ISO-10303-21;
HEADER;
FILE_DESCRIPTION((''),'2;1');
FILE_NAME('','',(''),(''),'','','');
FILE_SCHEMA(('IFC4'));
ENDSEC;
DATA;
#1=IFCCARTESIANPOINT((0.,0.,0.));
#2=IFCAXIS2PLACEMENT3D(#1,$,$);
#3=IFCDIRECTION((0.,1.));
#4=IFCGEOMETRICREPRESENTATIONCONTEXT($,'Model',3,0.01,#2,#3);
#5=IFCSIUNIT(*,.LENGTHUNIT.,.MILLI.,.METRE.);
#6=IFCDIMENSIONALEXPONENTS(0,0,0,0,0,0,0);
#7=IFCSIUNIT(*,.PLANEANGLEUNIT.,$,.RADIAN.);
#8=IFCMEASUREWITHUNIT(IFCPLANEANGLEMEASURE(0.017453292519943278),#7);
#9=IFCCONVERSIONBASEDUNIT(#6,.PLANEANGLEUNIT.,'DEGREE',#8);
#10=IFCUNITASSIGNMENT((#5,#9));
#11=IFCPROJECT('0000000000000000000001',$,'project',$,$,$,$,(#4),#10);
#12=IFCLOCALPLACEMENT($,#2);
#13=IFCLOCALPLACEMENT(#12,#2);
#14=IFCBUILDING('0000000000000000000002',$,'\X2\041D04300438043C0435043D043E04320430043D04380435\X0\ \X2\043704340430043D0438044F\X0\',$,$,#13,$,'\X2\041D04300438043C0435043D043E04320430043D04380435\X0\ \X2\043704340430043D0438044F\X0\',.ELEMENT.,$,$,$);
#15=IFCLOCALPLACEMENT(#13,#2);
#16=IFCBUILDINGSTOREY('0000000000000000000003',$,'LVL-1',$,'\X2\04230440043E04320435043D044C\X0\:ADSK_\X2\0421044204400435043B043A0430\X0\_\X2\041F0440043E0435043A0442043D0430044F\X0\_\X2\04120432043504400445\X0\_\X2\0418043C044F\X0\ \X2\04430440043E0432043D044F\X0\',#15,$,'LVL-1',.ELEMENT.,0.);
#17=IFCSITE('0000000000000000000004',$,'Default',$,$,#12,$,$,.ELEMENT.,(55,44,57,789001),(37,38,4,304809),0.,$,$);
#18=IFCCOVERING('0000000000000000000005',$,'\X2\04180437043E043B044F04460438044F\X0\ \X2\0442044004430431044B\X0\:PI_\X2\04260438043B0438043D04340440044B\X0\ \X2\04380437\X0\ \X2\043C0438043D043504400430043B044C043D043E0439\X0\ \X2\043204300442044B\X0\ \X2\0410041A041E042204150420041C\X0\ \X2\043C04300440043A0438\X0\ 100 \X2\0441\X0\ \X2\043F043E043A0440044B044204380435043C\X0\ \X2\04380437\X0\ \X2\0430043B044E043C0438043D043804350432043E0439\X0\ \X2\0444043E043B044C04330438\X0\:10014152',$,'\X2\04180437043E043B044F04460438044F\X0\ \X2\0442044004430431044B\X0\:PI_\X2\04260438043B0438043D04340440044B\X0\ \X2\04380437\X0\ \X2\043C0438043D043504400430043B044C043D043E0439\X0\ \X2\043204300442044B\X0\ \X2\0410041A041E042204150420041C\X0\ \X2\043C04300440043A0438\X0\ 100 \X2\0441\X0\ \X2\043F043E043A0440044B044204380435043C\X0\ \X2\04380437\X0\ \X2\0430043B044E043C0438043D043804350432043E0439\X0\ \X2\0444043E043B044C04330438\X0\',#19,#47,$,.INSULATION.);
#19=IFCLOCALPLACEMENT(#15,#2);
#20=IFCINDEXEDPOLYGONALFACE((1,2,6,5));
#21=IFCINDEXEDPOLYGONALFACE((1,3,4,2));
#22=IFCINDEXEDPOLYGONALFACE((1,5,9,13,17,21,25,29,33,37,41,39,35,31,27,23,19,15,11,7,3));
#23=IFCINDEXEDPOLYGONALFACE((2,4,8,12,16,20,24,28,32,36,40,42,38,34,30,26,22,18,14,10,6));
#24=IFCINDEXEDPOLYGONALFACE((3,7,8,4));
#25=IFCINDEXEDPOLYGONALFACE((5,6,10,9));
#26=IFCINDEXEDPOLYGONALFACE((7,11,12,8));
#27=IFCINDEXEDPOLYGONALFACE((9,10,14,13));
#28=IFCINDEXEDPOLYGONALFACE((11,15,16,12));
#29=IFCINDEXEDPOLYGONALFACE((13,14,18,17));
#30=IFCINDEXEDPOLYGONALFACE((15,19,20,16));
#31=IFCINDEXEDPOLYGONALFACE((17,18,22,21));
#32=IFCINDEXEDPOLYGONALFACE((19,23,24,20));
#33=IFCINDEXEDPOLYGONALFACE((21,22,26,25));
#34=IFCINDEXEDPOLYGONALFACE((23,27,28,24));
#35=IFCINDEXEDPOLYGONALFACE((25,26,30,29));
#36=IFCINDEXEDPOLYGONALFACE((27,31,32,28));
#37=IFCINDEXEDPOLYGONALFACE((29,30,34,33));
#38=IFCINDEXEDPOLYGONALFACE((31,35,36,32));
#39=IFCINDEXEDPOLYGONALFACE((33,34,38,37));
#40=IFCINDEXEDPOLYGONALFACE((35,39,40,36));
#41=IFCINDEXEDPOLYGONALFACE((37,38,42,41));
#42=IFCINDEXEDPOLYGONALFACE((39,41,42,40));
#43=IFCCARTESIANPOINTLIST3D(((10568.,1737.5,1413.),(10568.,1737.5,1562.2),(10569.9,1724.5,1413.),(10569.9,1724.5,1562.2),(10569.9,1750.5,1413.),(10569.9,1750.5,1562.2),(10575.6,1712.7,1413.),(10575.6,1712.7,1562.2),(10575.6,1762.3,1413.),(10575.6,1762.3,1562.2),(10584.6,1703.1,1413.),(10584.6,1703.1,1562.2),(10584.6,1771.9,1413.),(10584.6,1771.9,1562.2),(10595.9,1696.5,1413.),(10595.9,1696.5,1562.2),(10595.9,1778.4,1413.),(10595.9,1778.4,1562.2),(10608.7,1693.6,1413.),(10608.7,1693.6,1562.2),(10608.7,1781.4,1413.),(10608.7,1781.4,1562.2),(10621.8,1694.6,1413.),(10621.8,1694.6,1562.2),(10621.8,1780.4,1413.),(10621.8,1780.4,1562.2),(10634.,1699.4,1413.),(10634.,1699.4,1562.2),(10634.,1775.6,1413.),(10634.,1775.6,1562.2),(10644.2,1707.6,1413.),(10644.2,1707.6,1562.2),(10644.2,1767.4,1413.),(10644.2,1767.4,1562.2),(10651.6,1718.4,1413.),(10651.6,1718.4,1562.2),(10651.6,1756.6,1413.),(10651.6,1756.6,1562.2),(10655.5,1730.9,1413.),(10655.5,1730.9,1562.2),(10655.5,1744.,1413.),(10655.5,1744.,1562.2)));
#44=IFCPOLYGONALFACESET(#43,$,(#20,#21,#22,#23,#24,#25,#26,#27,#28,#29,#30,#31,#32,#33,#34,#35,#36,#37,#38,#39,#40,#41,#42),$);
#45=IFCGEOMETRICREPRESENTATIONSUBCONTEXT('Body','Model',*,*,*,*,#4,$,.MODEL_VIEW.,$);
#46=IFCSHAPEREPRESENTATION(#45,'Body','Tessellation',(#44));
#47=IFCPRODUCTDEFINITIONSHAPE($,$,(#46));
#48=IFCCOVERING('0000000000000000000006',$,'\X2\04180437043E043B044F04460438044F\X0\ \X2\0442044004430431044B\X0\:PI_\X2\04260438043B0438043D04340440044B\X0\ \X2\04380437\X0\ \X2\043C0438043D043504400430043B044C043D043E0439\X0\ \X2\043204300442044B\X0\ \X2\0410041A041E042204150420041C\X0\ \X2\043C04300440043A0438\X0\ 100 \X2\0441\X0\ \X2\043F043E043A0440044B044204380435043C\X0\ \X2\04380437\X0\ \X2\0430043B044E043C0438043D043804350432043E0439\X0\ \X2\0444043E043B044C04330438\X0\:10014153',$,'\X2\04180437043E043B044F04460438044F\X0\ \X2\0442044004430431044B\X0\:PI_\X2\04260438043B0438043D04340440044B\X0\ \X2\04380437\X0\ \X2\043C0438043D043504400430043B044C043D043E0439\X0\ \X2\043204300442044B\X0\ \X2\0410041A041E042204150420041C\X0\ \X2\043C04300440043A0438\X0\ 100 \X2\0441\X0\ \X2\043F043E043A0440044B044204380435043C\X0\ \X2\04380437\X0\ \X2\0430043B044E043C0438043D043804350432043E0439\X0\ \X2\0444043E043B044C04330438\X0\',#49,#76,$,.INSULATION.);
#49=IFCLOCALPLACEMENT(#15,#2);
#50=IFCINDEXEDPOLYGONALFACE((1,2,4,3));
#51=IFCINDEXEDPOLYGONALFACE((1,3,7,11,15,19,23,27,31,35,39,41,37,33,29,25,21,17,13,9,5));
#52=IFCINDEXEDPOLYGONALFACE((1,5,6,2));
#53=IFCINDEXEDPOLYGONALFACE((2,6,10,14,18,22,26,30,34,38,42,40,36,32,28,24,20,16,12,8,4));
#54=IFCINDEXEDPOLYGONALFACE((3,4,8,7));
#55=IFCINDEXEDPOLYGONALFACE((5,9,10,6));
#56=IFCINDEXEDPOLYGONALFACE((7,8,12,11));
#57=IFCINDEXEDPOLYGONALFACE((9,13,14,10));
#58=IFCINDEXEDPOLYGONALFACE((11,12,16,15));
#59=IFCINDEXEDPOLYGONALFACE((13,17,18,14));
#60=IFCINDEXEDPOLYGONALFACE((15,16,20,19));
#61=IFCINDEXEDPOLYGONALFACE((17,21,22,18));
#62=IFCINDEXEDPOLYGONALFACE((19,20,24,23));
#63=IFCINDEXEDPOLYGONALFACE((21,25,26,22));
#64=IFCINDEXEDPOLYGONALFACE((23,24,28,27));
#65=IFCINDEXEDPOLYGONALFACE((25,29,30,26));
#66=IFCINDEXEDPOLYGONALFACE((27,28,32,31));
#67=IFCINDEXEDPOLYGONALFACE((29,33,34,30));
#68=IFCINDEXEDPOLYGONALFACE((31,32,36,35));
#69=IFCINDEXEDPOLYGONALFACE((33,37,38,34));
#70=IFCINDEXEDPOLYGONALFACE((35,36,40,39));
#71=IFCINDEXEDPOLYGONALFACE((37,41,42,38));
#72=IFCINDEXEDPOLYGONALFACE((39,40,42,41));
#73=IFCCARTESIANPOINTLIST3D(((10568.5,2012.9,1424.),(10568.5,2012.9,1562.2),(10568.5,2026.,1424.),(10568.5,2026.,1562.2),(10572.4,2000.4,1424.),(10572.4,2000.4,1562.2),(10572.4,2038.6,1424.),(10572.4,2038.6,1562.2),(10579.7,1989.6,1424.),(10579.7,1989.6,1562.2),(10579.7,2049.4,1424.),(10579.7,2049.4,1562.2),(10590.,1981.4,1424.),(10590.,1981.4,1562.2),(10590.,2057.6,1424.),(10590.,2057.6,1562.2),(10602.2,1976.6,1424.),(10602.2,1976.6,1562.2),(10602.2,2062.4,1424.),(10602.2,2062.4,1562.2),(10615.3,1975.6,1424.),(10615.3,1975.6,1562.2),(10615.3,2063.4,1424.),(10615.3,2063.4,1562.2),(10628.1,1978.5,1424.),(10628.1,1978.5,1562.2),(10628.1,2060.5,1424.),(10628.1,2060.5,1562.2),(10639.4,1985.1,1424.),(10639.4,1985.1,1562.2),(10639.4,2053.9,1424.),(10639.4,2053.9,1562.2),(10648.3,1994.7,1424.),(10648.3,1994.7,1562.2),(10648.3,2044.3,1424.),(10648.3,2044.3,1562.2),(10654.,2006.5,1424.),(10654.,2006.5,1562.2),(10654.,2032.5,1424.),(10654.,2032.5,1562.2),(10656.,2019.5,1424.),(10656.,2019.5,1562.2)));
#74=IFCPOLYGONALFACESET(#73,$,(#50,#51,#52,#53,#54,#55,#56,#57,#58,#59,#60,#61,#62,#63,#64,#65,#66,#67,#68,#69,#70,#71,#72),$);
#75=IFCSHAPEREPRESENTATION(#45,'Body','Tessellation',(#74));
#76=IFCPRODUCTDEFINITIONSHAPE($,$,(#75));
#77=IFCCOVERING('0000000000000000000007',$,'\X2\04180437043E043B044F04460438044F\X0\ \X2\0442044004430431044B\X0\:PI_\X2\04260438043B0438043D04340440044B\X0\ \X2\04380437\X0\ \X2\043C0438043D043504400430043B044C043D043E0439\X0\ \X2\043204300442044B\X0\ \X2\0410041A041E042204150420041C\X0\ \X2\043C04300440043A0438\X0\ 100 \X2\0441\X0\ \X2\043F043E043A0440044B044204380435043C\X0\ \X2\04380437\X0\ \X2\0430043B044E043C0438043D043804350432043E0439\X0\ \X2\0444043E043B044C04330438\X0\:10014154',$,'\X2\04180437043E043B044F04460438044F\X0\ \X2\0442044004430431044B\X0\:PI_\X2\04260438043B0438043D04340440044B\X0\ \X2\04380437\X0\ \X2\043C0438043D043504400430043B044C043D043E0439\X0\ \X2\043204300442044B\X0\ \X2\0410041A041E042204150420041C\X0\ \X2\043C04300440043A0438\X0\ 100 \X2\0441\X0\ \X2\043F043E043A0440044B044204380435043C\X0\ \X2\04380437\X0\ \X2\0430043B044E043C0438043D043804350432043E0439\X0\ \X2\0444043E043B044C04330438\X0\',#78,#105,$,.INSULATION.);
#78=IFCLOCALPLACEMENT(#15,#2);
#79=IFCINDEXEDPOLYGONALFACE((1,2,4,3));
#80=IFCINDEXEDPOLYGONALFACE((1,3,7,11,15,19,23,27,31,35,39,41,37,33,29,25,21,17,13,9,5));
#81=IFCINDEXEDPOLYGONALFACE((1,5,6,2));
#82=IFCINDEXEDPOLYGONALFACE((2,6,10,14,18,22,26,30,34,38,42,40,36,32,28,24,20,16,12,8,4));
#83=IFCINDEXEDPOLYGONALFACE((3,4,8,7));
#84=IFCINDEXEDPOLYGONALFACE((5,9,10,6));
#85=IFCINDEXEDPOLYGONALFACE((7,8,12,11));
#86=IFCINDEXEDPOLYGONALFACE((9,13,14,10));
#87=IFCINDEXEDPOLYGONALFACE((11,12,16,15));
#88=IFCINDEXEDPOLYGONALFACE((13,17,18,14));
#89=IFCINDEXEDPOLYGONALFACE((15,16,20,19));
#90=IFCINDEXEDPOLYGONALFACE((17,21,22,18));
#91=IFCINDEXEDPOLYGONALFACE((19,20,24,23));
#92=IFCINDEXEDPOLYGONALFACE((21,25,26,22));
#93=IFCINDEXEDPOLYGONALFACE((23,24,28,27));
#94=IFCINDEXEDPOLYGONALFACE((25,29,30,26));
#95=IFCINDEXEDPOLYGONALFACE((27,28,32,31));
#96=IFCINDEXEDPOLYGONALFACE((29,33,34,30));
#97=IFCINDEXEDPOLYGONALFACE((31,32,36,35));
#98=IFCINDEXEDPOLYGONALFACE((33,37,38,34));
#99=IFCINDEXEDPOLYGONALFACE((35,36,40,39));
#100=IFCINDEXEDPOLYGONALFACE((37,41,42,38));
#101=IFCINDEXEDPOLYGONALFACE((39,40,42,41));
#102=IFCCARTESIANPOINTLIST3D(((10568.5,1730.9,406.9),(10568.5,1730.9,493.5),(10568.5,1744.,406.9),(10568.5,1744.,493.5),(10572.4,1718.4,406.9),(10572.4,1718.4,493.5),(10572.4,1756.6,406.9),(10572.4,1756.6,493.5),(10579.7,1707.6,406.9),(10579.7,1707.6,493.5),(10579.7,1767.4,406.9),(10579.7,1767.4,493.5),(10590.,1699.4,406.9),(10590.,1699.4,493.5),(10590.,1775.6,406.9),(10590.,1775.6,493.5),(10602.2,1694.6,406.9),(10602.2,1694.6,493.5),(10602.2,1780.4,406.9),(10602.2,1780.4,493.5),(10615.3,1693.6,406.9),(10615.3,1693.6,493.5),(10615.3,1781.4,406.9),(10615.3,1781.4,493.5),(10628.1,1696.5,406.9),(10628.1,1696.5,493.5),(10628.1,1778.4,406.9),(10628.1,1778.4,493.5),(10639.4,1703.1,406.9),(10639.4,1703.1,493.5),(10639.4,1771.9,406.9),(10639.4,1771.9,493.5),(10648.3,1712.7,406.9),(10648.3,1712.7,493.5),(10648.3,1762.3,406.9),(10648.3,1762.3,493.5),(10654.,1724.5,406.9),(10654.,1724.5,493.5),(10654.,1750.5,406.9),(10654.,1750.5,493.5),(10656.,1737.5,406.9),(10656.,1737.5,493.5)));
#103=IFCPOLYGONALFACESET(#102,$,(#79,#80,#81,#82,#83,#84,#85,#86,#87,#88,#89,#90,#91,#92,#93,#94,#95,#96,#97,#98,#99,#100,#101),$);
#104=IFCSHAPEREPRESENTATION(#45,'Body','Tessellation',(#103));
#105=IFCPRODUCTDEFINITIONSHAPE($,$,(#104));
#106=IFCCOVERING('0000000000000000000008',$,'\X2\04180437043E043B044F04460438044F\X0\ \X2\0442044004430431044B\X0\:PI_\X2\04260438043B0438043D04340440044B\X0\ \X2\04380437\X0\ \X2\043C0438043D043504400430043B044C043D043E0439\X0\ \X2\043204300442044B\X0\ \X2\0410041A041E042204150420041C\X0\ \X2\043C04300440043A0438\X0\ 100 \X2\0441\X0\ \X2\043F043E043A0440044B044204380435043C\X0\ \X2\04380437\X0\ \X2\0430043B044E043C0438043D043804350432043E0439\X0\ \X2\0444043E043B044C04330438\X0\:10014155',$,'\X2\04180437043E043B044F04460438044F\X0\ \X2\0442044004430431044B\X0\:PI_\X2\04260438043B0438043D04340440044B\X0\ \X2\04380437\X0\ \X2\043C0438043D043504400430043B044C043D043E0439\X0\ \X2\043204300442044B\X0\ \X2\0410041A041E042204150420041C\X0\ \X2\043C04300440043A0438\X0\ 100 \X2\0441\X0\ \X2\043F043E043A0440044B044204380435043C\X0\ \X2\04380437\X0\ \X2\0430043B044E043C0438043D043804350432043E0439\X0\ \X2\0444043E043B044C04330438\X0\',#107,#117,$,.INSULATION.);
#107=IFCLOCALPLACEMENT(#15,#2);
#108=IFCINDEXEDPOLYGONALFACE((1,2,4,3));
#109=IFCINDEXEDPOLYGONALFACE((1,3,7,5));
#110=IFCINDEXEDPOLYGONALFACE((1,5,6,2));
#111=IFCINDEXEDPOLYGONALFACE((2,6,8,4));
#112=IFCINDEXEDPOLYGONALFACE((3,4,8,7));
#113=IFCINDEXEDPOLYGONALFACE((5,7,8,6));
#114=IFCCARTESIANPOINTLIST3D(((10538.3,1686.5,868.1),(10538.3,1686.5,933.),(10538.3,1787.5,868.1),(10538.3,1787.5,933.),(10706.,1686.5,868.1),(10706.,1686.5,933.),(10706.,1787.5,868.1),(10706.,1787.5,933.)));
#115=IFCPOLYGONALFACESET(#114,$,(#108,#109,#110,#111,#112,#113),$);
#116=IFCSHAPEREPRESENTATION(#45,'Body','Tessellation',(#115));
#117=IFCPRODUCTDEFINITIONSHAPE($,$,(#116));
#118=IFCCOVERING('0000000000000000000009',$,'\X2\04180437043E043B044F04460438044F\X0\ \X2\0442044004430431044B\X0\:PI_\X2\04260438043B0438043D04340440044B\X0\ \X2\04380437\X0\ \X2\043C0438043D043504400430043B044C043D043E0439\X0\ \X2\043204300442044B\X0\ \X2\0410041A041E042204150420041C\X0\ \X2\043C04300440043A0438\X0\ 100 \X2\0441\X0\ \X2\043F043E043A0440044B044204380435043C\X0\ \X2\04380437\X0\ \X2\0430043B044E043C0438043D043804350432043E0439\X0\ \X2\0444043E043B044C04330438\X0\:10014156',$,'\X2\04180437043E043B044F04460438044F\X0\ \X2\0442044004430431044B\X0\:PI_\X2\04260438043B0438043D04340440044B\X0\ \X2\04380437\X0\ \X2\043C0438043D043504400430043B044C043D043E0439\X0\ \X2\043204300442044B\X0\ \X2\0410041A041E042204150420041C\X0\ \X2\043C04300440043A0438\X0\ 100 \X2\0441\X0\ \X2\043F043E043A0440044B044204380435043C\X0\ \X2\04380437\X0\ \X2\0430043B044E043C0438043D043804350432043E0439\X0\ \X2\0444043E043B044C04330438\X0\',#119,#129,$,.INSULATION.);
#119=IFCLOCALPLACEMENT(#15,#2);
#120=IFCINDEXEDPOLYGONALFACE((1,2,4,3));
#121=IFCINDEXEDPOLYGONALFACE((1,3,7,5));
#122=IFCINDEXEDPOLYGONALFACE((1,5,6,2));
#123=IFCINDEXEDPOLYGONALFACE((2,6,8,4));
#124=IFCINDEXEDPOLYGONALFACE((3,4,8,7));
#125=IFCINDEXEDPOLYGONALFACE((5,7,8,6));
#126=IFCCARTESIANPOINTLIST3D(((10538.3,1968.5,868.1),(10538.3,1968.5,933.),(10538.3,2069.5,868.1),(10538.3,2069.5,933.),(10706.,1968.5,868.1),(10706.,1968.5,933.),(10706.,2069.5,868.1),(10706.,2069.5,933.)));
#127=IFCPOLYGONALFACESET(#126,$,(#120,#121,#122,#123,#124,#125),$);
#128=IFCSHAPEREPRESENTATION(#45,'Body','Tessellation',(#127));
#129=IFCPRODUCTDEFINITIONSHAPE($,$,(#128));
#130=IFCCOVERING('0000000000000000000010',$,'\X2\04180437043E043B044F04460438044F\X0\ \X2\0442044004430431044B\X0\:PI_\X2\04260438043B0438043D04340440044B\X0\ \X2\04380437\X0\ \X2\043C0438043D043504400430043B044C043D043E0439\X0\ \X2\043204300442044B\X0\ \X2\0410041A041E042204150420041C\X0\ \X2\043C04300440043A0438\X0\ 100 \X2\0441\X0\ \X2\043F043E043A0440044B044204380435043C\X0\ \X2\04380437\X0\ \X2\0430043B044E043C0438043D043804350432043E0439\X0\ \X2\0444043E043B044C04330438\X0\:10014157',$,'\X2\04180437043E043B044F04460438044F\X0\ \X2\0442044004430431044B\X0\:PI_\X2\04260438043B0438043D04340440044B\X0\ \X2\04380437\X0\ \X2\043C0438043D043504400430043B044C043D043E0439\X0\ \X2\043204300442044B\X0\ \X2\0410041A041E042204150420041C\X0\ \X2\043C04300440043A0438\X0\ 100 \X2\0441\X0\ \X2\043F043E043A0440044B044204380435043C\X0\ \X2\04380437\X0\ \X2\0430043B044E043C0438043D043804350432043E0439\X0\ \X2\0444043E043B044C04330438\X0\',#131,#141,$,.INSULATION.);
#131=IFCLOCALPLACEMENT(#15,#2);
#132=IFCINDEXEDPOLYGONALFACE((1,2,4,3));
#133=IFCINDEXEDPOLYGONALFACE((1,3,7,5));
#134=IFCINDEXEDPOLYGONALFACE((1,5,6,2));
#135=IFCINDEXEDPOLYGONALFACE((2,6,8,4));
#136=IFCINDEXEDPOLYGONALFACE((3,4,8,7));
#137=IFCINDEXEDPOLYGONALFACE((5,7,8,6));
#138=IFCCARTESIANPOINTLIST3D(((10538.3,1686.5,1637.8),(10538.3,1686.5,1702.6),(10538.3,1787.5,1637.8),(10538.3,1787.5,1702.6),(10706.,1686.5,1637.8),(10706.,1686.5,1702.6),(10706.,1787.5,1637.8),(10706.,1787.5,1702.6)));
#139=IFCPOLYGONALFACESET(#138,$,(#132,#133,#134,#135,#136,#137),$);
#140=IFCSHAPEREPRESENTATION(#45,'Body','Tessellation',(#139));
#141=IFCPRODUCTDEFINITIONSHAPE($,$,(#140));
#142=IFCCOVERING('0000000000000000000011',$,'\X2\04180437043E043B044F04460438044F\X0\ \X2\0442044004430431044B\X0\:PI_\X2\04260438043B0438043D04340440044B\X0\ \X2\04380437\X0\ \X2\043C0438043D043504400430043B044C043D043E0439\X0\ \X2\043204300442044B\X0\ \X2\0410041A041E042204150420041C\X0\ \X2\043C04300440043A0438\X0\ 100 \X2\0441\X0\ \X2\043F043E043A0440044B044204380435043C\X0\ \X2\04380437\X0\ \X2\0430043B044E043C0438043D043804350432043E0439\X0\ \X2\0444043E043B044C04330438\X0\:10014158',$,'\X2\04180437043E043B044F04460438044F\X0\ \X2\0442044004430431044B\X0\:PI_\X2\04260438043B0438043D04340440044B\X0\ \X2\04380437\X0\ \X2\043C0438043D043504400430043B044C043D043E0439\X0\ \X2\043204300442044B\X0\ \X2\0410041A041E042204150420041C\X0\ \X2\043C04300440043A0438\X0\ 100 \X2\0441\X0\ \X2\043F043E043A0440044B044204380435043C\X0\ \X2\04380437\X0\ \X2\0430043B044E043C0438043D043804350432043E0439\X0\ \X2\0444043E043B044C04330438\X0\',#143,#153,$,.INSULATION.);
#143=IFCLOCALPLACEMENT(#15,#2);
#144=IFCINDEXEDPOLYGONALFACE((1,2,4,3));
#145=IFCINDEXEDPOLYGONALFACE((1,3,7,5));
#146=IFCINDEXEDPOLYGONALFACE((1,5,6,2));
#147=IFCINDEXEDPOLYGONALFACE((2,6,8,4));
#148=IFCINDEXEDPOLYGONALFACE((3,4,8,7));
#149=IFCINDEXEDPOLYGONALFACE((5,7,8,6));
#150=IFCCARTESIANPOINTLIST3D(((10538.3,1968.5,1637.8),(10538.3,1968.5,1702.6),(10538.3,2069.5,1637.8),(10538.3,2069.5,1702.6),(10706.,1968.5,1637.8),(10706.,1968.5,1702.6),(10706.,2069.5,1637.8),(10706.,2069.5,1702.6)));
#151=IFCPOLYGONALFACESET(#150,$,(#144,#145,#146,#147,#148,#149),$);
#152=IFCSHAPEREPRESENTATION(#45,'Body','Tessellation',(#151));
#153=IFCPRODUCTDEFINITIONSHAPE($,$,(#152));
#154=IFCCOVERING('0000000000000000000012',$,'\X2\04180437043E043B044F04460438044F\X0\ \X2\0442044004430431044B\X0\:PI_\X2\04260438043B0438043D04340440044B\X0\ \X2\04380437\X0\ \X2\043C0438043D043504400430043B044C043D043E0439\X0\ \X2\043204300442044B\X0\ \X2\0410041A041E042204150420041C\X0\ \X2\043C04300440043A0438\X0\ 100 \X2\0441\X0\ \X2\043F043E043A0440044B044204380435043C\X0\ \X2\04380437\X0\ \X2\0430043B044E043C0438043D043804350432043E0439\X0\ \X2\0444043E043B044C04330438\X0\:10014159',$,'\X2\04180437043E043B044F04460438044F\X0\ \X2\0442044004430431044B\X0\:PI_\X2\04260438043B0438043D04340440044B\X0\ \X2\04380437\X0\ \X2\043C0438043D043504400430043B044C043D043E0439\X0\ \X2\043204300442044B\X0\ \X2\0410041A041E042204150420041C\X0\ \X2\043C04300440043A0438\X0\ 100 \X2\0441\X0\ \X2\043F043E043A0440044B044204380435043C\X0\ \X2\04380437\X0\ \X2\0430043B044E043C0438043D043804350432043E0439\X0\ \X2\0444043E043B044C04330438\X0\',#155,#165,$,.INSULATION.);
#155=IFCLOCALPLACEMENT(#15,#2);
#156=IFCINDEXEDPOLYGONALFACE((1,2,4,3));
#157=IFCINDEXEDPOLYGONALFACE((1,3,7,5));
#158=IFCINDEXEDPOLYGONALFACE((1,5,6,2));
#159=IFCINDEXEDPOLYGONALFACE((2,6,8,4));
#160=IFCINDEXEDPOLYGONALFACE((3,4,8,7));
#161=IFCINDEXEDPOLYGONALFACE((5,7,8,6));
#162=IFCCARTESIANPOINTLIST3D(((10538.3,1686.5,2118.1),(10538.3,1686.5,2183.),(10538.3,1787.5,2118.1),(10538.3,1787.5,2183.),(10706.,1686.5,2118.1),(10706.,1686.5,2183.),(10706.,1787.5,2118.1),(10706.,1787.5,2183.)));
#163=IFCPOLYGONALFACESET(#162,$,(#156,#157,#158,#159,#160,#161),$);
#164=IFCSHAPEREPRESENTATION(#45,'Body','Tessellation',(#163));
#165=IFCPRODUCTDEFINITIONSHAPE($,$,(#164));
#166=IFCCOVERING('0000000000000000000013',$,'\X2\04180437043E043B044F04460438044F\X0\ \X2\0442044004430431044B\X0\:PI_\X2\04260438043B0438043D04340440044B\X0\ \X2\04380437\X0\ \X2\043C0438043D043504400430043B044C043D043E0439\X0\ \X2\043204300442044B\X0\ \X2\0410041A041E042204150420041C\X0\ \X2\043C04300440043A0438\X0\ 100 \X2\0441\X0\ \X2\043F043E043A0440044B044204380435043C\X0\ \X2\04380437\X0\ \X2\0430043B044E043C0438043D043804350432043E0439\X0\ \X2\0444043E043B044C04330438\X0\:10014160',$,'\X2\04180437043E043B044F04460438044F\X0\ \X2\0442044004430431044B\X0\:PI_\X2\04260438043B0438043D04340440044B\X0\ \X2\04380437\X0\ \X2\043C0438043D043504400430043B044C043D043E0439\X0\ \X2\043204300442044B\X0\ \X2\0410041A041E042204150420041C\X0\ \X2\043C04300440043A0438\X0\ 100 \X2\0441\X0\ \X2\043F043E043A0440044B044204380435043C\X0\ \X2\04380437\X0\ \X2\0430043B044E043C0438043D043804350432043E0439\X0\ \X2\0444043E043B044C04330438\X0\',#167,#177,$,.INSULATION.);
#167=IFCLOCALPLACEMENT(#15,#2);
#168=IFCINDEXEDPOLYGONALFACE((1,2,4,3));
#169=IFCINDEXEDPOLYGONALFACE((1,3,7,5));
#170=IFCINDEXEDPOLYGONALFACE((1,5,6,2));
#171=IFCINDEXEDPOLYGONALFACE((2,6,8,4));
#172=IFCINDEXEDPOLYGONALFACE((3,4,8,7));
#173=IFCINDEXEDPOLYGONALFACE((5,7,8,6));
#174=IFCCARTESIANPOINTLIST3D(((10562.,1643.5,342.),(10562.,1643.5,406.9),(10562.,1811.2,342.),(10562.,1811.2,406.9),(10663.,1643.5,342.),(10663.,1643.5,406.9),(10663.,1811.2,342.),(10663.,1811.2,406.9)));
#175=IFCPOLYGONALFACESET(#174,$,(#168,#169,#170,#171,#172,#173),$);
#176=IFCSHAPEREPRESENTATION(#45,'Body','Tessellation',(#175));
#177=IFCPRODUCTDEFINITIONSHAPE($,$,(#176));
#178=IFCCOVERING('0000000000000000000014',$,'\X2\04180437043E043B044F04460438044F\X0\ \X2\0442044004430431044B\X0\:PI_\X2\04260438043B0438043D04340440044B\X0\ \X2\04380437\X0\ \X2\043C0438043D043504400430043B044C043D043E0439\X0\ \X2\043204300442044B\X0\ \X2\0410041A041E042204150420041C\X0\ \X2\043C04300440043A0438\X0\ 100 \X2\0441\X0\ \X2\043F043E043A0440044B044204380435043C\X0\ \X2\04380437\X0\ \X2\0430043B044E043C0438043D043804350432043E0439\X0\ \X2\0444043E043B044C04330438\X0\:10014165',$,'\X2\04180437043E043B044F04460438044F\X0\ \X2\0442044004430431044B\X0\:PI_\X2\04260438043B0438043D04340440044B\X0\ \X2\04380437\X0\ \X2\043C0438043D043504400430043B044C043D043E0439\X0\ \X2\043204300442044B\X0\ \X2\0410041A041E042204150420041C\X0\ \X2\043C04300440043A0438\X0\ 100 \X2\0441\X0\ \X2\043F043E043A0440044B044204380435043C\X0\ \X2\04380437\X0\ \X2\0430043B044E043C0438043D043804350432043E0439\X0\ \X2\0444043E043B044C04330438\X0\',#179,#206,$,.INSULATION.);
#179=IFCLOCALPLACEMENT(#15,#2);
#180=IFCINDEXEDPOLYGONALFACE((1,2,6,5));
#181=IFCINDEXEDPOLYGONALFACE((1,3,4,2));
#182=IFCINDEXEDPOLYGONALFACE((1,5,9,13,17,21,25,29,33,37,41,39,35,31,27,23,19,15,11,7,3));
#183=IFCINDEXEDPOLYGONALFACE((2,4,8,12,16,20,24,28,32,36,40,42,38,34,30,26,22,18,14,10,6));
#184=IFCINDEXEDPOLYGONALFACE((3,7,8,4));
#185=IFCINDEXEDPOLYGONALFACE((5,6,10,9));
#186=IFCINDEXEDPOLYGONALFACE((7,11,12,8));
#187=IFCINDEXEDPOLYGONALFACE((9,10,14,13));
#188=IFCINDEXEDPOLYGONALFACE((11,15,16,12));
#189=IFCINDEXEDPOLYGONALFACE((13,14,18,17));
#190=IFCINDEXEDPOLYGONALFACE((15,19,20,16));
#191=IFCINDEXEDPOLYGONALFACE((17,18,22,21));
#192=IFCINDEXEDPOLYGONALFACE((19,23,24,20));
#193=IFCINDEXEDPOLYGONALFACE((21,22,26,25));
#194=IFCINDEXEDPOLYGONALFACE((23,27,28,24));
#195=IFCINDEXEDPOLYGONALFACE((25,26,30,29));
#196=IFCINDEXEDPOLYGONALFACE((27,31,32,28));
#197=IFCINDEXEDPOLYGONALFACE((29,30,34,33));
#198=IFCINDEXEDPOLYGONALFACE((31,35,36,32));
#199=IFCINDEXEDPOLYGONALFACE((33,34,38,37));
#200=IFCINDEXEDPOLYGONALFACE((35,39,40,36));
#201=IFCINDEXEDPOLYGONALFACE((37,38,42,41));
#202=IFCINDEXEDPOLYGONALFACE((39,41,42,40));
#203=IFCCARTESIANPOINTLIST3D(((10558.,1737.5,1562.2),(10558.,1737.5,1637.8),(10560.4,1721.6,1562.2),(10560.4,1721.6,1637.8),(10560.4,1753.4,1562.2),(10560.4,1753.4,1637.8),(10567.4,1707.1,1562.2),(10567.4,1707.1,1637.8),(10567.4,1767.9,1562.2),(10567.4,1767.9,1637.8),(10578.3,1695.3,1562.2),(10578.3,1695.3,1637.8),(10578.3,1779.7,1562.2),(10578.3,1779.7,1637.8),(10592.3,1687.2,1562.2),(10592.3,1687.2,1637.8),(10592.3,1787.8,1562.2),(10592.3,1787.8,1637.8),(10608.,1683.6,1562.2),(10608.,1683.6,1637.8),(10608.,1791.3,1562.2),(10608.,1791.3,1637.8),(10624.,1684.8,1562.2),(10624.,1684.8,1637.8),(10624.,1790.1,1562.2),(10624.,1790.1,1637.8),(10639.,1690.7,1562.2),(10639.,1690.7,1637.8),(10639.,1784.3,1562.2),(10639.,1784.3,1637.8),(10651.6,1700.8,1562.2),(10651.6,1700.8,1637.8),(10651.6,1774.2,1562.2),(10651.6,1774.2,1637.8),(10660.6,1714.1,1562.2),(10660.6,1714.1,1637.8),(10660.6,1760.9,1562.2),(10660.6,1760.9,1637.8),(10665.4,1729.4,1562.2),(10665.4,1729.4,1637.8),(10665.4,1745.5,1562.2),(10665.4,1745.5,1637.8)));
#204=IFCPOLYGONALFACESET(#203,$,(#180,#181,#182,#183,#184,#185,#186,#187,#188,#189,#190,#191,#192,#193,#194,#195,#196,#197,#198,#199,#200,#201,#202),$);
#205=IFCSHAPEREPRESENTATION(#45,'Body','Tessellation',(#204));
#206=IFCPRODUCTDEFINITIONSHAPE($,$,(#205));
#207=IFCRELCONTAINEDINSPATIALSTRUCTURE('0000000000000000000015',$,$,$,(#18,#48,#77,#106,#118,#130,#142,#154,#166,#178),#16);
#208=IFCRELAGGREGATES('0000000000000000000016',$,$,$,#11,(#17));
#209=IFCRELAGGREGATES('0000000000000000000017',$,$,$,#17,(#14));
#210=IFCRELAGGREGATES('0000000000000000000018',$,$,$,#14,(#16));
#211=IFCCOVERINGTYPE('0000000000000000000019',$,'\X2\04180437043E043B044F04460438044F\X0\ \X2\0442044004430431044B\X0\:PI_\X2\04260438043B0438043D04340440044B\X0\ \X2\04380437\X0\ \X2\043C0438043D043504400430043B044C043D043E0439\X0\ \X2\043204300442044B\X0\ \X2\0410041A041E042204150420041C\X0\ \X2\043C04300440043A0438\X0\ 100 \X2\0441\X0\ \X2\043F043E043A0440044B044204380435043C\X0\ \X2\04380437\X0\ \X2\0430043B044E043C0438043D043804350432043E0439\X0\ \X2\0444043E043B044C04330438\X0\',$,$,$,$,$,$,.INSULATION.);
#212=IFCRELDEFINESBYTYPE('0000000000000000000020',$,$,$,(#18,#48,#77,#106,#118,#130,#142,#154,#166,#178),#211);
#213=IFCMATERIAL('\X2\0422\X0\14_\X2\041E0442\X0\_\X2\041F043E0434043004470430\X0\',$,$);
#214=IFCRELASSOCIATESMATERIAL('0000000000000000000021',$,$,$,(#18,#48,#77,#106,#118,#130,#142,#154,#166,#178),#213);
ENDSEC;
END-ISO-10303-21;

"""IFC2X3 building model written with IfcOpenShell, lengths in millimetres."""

from ifc_helpers import new_model, entity, si_unit, converted_unit, direction, frame, frame_2d, origin, place, context, subcontext, project, spatial, rectangle, circle, extrude, material, type_object, element, save


model = new_model("IFC2X3")

# Units and contexts
model_context = context("Model", 3, precision=0.01, world=origin(), true_north=direction((0.0, 1.0)))
body_context = subcontext(model_context, "Body", "Model", "MODEL_VIEW")
ifc_project = project(units=[si_unit("LENGTHUNIT", "METRE", prefix="MILLI"), converted_unit("PLANEANGLEUNIT", "DEGREE", entity("IfcPlaneAngleMeasure", 0.017453292519943278), si_unit("PLANEANGLEUNIT", "RADIAN"), dimensions=[0, 0, 0, 0, 0, 0, 0])], contexts=[model_context])

# Site, building, storey
site_placement = place(None, origin())
site = spatial("IfcSite", under=ifc_project, at=site_placement, Name="Default", CompositionType="ELEMENT", RefLatitude=(55, 44, 57, 789001), RefLongitude=(37, 38, 4, 304809), RefElevation=0.0)
building_placement = place(site_placement, origin())
building = spatial("IfcBuilding", under=site, at=building_placement, Name="Наименование здания", LongName="Наименование здания", CompositionType="ELEMENT")
storey_placement = place(building_placement, origin())
storey = spatial("IfcBuildingStorey", under=building, at=storey_placement, Name="LVL-1", ObjectType="Уровень:ADSK_Стрелка_Проектная_Вверх_Имя уровня", LongName="LVL-1", CompositionType="ELEMENT", Elevation=0.0)

# Coverings
ifc_material_1 = material(Name="Т14_От_Подача")
covering_type_1 = type_object("IfcCoveringType", Name="Изоляция трубы:PI_Цилиндры из минеральной ваты АКОТЕРМ марки 100 с покрытием из алюминиевой фольги", PredefinedType="INSULATION")
covering_1_placement = place(storey_placement, origin())
element("IfcCovering", 1, at=covering_1_placement, inside=storey, type_object=covering_type_1, material=ifc_material_1, Name="Изоляция трубы:PI_Цилиндры из минеральной ваты АКОТЕРМ марки 100 с покрытием из алюминиевой фольги:10014152", ObjectType="Изоляция трубы:PI_Цилиндры из минеральной ваты АКОТЕРМ марки 100 с покрытием из алюминиевой фольги", PredefinedType="INSULATION", context=body_context, shape_type="SweptSolid", body=[
    extrude(circle(Radius=44.0, at=frame_2d((0.0, 0.0), x_axis=(1.0, 0.0))), frame((10612.0, 1737.5, 1413.0), z_axis=(0.0, 0.0, 1.0), x_axis=(-1.0, 0.0, 0.0)), (0.0, 0.0, 1.0), 149.2),
])
covering_2_placement = place(storey_placement, origin())
element("IfcCovering", 2, at=covering_2_placement, inside=storey, type_object=covering_type_1, material=ifc_material_1, Name="Изоляция трубы:PI_Цилиндры из минеральной ваты АКОТЕРМ марки 100 с покрытием из алюминиевой фольги:10014153", ObjectType="Изоляция трубы:PI_Цилиндры из минеральной ваты АКОТЕРМ марки 100 с покрытием из алюминиевой фольги", PredefinedType="INSULATION", context=body_context, shape_type="SweptSolid", body=[
    extrude(circle(Radius=44.0, at=frame_2d((0.0, 0.0), x_axis=(1.0, 0.0))), frame((10612.0, 2019.5, 1424.0)), (0.0, 0.0, 1.0), 138.2),
])
covering_3_placement = place(storey_placement, origin())
element("IfcCovering", 3, at=covering_3_placement, inside=storey, type_object=covering_type_1, material=ifc_material_1, Name="Изоляция трубы:PI_Цилиндры из минеральной ваты АКОТЕРМ марки 100 с покрытием из алюминиевой фольги:10014154", ObjectType="Изоляция трубы:PI_Цилиндры из минеральной ваты АКОТЕРМ марки 100 с покрытием из алюминиевой фольги", PredefinedType="INSULATION", context=body_context, shape_type="SweptSolid", body=[
    extrude(circle(Radius=44.0, at=frame_2d((0.0, 0.0), x_axis=(1.0, 0.0))), frame((10612.0, 1737.5, 406.9)), (0.0, 0.0, 1.0), 86.6),
])
covering_4_placement = place(storey_placement, origin())
element("IfcCovering", 4, at=covering_4_placement, inside=storey, type_object=covering_type_1, material=ifc_material_1, Name="Изоляция трубы:PI_Цилиндры из минеральной ваты АКОТЕРМ марки 100 с покрытием из алюминиевой фольги:10014155", ObjectType="Изоляция трубы:PI_Цилиндры из минеральной ваты АКОТЕРМ марки 100 с покрытием из алюминиевой фольги", PredefinedType="INSULATION", context=body_context, shape_type="SweptSolid", body=[
    extrude(rectangle(XDim=167.7, YDim=101.0, at=frame_2d((0.0, 0.0), x_axis=(1.0, 0.0))), frame((10622.1, 1737.0, 868.1)), (0.0, 0.0, 1.0), 64.9),
])
covering_5_placement = place(storey_placement, origin())
element("IfcCovering", 5, at=covering_5_placement, inside=storey, type_object=covering_type_1, material=ifc_material_1, Name="Изоляция трубы:PI_Цилиндры из минеральной ваты АКОТЕРМ марки 100 с покрытием из алюминиевой фольги:10014156", ObjectType="Изоляция трубы:PI_Цилиндры из минеральной ваты АКОТЕРМ марки 100 с покрытием из алюминиевой фольги", PredefinedType="INSULATION", context=body_context, shape_type="SweptSolid", body=[
    extrude(rectangle(XDim=167.7, YDim=101.0, at=frame_2d((0.0, 0.0), x_axis=(1.0, 0.0))), frame((10622.1, 2019.0, 868.1)), (0.0, 0.0, 1.0), 64.9),
])
covering_6_placement = place(storey_placement, origin())
element("IfcCovering", 6, at=covering_6_placement, inside=storey, type_object=covering_type_1, material=ifc_material_1, Name="Изоляция трубы:PI_Цилиндры из минеральной ваты АКОТЕРМ марки 100 с покрытием из алюминиевой фольги:10014157", ObjectType="Изоляция трубы:PI_Цилиндры из минеральной ваты АКОТЕРМ марки 100 с покрытием из алюминиевой фольги", PredefinedType="INSULATION", context=body_context, shape_type="SweptSolid", body=[
    extrude(rectangle(XDim=167.7, YDim=101.0, at=frame_2d((0.0, 0.0), x_axis=(1.0, 0.0))), frame((10622.1, 1737.0, 1637.8)), (0.0, 0.0, 1.0), 64.9),
])
covering_7_placement = place(storey_placement, origin())
element("IfcCovering", 7, at=covering_7_placement, inside=storey, type_object=covering_type_1, material=ifc_material_1, Name="Изоляция трубы:PI_Цилиндры из минеральной ваты АКОТЕРМ марки 100 с покрытием из алюминиевой фольги:10014158", ObjectType="Изоляция трубы:PI_Цилиндры из минеральной ваты АКОТЕРМ марки 100 с покрытием из алюминиевой фольги", PredefinedType="INSULATION", context=body_context, shape_type="SweptSolid", body=[
    extrude(rectangle(XDim=167.7, YDim=101.0, at=frame_2d((0.0, 0.0), x_axis=(1.0, 0.0))), frame((10622.1, 2019.0, 1637.8)), (0.0, 0.0, 1.0), 64.9),
])
covering_8_placement = place(storey_placement, origin())
element("IfcCovering", 8, at=covering_8_placement, inside=storey, type_object=covering_type_1, material=ifc_material_1, Name="Изоляция трубы:PI_Цилиндры из минеральной ваты АКОТЕРМ марки 100 с покрытием из алюминиевой фольги:10014159", ObjectType="Изоляция трубы:PI_Цилиндры из минеральной ваты АКОТЕРМ марки 100 с покрытием из алюминиевой фольги", PredefinedType="INSULATION", context=body_context, shape_type="SweptSolid", body=[
    extrude(rectangle(XDim=167.7, YDim=101.0, at=frame_2d((0.0, 0.0), x_axis=(1.0, 0.0))), frame((10622.1, 1737.0, 2118.1)), (0.0, 0.0, 1.0), 64.9),
])
covering_9_placement = place(storey_placement, origin())
element("IfcCovering", 9, at=covering_9_placement, inside=storey, type_object=covering_type_1, material=ifc_material_1, Name="Изоляция трубы:PI_Цилиндры из минеральной ваты АКОТЕРМ марки 100 с покрытием из алюминиевой фольги:10014160", ObjectType="Изоляция трубы:PI_Цилиндры из минеральной ваты АКОТЕРМ марки 100 с покрытием из алюминиевой фольги", PredefinedType="INSULATION", context=body_context, shape_type="SweptSolid", body=[
    extrude(rectangle(XDim=167.7, YDim=101.0, at=frame_2d((0.0, 0.0), x_axis=(1.0, 0.0))), frame((10612.5, 1727.4, 342.0), z_axis=(0.0, 0.0, 1.0), x_axis=(0.0, 1.0, 0.0)), (0.0, 0.0, 1.0), 64.9),
])
covering_10_placement = place(storey_placement, origin())
element("IfcCovering", 10, at=covering_10_placement, inside=storey, type_object=covering_type_1, material=ifc_material_1, Name="Изоляция трубы:PI_Цилиндры из минеральной ваты АКОТЕРМ марки 100 с покрытием из алюминиевой фольги:10014165", ObjectType="Изоляция трубы:PI_Цилиндры из минеральной ваты АКОТЕРМ марки 100 с покрытием из алюминиевой фольги", PredefinedType="INSULATION", context=body_context, shape_type="SweptSolid", body=[
    extrude(circle(Radius=54.0, at=frame_2d((0.0, 0.0), x_axis=(1.0, 0.0))), frame((10612.0, 1737.5, 1562.2), z_axis=(0.0, 0.0, 1.0), x_axis=(-1.0, 0.0, 0.0)), (0.0, 0.0, 1.0), 75.5),
])

save(model, "model.ifc")
